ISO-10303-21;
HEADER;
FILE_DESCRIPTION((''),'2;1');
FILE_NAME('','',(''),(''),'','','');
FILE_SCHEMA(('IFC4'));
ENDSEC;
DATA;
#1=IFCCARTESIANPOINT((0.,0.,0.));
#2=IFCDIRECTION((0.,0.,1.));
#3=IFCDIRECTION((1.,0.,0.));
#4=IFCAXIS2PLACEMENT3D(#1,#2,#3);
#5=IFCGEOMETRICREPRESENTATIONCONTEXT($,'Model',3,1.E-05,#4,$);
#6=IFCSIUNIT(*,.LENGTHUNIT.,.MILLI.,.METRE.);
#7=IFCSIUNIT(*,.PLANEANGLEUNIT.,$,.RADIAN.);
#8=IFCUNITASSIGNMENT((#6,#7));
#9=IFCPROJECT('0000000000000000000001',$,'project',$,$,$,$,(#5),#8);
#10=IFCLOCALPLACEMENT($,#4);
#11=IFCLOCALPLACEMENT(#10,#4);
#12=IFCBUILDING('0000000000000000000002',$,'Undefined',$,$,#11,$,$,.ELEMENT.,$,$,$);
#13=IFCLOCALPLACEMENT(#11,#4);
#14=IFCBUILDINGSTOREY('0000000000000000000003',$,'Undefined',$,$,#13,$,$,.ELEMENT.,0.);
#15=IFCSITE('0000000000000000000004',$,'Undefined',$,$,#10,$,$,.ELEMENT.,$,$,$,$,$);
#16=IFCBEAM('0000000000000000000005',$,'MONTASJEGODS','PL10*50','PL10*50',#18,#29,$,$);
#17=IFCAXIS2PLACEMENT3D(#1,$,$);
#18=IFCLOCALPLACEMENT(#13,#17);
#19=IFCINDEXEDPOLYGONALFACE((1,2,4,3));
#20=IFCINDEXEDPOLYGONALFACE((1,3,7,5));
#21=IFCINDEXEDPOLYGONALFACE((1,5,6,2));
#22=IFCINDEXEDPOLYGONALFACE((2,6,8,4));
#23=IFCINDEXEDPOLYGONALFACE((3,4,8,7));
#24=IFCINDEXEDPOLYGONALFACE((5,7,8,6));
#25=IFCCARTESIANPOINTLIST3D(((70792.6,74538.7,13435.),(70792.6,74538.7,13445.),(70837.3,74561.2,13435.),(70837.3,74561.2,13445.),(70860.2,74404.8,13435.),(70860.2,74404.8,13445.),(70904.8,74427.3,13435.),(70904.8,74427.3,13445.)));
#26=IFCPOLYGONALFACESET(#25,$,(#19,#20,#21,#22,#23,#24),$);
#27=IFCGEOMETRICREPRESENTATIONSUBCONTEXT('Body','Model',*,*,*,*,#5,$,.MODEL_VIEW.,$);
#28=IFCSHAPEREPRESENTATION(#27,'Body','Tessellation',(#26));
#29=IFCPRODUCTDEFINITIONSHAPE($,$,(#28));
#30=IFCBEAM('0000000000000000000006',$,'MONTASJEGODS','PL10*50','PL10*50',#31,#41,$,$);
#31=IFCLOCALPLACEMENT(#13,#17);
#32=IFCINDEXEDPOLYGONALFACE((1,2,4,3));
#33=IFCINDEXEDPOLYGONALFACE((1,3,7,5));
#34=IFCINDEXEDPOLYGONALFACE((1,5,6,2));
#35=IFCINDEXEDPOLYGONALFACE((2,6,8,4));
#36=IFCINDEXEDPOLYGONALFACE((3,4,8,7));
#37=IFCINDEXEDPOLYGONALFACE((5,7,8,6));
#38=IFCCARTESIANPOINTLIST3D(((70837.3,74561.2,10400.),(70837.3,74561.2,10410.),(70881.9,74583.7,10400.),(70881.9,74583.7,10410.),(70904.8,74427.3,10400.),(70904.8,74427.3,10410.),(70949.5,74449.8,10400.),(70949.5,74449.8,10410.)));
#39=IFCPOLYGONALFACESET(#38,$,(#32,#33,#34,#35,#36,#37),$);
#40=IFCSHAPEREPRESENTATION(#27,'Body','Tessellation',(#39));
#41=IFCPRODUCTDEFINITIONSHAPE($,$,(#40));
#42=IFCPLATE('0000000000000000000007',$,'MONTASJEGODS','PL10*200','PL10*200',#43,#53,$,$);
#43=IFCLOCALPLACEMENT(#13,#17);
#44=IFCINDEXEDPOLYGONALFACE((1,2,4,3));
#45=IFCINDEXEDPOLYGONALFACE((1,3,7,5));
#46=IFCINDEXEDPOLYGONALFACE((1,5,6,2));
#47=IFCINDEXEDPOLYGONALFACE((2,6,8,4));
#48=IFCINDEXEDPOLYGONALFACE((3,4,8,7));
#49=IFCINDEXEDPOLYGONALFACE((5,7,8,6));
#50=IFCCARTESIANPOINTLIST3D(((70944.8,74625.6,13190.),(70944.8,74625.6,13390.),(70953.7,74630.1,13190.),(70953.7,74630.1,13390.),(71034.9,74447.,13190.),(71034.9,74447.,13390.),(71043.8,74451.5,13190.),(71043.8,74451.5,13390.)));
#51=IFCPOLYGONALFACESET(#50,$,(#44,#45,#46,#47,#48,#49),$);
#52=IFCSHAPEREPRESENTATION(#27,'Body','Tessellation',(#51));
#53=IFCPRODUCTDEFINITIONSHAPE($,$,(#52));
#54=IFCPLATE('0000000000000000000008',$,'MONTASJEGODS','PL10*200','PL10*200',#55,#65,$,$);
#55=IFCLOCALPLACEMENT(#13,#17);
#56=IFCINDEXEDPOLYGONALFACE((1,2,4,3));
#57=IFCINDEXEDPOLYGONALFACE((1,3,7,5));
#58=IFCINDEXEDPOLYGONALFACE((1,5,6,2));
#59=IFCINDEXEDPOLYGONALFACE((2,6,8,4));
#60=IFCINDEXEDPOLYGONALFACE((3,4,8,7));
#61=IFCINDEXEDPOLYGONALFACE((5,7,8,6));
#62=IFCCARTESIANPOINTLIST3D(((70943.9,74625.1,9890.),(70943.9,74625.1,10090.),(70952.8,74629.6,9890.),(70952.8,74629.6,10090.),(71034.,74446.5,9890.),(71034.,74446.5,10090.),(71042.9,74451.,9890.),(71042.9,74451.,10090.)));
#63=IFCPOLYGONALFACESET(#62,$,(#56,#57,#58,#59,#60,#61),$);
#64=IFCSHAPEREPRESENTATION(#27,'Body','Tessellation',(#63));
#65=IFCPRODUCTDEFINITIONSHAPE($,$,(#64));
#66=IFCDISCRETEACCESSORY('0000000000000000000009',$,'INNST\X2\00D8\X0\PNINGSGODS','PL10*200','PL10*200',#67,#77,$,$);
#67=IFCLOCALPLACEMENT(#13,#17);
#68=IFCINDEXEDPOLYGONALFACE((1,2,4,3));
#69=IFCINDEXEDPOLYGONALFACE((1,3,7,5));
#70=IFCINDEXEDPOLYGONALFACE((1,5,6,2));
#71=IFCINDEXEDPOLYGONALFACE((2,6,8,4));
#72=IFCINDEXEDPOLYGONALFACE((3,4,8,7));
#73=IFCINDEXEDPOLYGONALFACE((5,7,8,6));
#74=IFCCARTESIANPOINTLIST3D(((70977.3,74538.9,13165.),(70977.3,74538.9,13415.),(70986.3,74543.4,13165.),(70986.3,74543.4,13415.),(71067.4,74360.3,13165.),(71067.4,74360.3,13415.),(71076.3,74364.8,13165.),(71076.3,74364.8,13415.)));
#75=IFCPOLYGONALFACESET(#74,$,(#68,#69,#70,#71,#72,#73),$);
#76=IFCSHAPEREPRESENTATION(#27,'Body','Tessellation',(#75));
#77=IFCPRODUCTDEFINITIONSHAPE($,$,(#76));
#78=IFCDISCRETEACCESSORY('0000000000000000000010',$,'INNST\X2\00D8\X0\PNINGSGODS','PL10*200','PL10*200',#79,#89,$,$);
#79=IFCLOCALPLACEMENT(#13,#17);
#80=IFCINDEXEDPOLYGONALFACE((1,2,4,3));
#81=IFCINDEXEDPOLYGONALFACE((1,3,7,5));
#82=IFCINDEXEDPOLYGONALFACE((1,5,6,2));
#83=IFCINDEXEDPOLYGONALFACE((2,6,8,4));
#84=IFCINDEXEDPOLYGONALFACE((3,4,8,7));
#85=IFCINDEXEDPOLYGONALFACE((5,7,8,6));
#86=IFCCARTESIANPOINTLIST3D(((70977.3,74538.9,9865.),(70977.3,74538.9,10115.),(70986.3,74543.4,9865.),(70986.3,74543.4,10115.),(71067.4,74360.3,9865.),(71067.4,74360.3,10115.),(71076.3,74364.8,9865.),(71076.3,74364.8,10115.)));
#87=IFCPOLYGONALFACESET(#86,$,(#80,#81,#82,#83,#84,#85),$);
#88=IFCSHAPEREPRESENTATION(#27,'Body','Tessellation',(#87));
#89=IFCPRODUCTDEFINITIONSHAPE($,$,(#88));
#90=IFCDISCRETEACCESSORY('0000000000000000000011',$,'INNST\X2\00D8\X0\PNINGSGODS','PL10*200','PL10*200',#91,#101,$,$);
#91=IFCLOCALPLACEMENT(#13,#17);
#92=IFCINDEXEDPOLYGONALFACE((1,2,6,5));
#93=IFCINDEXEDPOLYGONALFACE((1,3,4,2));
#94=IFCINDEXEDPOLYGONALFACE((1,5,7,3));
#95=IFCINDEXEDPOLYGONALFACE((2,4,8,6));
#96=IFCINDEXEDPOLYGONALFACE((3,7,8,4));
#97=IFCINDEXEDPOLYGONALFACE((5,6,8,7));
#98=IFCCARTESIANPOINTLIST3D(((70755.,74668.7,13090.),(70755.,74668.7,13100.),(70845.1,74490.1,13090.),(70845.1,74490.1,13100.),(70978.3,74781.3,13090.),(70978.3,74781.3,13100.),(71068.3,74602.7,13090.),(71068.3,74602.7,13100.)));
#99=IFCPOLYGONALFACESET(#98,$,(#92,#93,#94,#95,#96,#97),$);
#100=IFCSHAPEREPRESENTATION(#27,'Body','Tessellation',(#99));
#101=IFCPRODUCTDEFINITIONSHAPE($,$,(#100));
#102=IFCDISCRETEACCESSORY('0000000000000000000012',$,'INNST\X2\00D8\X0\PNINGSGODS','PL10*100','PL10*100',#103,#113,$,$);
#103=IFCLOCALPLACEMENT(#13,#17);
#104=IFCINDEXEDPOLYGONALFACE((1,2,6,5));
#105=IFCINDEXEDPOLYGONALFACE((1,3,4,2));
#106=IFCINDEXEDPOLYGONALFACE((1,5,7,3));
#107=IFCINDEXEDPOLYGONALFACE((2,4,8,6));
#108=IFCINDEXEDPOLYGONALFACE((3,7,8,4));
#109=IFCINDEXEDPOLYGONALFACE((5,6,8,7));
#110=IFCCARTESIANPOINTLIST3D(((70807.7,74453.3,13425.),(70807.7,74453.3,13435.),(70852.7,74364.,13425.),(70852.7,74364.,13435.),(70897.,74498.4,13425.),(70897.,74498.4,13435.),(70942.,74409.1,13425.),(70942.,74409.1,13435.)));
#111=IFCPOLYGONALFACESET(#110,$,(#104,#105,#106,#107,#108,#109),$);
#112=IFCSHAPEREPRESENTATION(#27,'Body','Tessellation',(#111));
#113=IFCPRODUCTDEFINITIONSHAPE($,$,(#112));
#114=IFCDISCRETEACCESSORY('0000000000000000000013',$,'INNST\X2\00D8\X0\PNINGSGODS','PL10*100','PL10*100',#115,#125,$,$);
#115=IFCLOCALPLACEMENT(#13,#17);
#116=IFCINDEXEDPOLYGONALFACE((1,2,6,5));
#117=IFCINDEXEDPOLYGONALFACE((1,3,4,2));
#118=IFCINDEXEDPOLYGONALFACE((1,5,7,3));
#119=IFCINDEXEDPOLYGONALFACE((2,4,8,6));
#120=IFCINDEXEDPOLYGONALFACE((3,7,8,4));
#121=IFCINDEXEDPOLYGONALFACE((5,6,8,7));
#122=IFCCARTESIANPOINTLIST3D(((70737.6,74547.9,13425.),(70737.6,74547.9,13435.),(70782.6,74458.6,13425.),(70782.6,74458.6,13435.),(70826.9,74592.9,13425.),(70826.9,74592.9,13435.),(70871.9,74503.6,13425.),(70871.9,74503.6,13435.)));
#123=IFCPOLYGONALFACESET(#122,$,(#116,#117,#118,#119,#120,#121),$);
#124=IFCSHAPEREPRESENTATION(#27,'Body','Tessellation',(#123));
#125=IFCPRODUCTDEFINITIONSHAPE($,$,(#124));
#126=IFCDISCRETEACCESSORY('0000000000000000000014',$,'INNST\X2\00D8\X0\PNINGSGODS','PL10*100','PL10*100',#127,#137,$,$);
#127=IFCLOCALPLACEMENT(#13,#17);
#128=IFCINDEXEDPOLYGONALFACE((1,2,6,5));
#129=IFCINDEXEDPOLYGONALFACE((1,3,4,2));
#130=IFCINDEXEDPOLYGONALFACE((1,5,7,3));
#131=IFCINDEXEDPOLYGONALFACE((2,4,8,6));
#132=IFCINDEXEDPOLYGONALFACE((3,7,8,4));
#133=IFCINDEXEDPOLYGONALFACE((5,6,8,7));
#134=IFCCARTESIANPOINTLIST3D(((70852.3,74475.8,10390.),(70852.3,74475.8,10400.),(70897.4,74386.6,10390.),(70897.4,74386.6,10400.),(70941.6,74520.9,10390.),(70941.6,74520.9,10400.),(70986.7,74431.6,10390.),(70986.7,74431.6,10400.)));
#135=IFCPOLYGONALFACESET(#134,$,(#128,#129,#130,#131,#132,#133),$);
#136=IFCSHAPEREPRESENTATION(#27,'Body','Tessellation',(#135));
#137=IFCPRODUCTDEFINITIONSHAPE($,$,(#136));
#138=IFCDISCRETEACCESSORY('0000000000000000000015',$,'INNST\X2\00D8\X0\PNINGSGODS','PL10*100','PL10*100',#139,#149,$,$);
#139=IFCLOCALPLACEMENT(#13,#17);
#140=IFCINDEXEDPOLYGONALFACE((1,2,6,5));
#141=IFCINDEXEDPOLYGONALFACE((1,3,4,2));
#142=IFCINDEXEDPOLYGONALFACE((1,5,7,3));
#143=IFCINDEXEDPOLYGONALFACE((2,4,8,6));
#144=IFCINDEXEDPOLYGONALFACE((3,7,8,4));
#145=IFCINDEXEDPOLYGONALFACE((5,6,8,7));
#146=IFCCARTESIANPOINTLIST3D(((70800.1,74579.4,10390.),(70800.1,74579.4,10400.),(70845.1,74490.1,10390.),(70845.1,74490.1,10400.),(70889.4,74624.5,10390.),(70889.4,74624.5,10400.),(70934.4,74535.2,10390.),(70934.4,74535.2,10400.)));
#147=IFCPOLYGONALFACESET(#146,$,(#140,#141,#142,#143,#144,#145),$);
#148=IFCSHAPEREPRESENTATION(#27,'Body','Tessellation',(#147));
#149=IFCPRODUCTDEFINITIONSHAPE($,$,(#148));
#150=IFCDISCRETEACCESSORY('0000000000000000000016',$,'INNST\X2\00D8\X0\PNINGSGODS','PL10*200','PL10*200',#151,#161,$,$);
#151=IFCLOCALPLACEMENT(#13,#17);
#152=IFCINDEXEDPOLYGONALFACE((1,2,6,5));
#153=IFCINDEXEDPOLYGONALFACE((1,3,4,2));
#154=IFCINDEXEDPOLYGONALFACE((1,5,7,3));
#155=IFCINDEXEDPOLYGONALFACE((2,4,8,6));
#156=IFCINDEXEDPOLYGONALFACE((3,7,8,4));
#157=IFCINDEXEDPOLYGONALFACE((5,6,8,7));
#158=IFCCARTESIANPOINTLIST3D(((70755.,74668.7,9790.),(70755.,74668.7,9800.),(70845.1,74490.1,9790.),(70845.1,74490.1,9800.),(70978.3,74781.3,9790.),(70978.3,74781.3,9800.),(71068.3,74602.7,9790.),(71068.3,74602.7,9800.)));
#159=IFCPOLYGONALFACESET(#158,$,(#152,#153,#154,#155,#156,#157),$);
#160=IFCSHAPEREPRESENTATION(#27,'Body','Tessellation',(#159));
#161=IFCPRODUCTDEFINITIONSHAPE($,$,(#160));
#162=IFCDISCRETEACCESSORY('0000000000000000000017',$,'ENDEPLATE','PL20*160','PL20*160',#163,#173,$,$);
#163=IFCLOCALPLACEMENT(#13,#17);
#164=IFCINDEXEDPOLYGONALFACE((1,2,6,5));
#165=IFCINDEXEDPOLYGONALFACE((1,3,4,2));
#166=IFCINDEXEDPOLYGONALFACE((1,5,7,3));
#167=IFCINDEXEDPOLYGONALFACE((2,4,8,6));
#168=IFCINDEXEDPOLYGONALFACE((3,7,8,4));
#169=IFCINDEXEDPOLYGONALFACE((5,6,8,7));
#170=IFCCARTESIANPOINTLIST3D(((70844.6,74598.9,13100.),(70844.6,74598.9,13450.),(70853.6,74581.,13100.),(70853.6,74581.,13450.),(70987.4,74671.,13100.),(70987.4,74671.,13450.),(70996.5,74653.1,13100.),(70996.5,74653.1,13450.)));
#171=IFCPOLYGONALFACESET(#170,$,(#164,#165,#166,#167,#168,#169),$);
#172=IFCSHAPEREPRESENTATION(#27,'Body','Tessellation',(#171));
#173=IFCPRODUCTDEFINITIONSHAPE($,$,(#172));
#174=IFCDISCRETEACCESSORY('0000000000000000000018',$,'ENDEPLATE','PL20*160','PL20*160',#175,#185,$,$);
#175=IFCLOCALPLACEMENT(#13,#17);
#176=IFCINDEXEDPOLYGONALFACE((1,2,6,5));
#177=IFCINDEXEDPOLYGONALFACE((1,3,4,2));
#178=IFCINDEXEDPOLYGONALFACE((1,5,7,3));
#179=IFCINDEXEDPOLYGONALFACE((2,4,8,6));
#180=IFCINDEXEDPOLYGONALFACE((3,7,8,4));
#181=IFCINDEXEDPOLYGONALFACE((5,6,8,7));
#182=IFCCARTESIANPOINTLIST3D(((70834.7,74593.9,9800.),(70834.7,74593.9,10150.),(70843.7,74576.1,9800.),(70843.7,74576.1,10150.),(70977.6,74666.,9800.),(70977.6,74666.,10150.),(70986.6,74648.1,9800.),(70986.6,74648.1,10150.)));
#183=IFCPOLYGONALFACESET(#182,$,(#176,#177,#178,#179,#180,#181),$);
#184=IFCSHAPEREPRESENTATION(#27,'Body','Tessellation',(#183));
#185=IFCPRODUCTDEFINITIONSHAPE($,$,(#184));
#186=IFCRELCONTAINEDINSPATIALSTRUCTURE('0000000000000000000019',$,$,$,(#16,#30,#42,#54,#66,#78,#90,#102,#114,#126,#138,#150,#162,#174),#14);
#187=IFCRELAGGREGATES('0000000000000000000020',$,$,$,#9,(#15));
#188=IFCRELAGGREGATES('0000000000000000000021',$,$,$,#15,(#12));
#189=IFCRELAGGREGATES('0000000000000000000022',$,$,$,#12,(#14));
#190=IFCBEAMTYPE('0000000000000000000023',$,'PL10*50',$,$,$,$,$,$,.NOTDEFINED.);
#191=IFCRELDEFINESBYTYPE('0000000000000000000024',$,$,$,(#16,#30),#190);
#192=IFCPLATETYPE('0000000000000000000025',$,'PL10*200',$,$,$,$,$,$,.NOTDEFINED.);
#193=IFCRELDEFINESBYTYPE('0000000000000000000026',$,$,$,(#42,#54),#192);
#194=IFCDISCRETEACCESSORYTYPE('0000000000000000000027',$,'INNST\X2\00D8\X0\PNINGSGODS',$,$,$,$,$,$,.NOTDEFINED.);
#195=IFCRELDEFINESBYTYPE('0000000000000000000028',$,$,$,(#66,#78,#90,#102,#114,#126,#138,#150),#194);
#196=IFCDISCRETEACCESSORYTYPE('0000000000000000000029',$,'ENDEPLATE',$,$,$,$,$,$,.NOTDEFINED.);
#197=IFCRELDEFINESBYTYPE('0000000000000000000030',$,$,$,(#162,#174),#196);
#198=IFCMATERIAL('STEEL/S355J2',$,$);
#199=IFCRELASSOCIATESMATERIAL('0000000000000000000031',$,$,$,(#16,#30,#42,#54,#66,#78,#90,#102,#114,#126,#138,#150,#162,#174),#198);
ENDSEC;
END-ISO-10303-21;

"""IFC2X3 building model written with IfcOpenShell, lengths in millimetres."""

from ifc_helpers import new_model, si_unit, frame, origin_with_axes, origin_2d_with_axis, place, context, subcontext, project, spatial, polyline, rectangle, outline, extrude, material, type_object, element, save


model = new_model("IFC2X3")

# Units and contexts
model_context = context("Model", 3, precision=1e-05, world=origin_with_axes())
body_context = subcontext(model_context, "Body", "Model", "MODEL_VIEW")
ifc_project = project(units=[si_unit("LENGTHUNIT", "METRE", prefix="MILLI"), si_unit("PLANEANGLEUNIT", "RADIAN")], contexts=[model_context])

# Site, building, storey
site_placement = place(None, origin_with_axes())
site = spatial("IfcSite", under=ifc_project, at=site_placement, Name="Undefined", CompositionType="ELEMENT")
building_placement = place(site_placement, origin_with_axes())
building = spatial("IfcBuilding", under=site, at=building_placement, Name="Undefined", CompositionType="ELEMENT")
storey_placement = place(building_placement, origin_with_axes())
storey = spatial("IfcBuildingStorey", under=building, at=storey_placement, Name="Undefined", CompositionType="ELEMENT", Elevation=0.0)

# Beams
ifc_material_1 = material(Name="STEEL/S355J2")
beam_type_1 = type_object("IfcBeamType", Name="PL10*50", PredefinedType="NOTDEFINED")
for number, where, z_axis, x_axis, name in (
    (1, (70815.0, 74550.0, 13440.0), (0.892821, 0.450411, 0.0), (0.450411, -0.892821, 0.0), "MONTASJEGODS"),
    (2, (70859.6, 74572.5, 10405.0), (0.892821, 0.450411, 0.0), (0.450411, -0.892821, 0.0), "MONTASJEGODS"),
):
    element("IfcBeam", number, at=place(storey_placement, frame(where, z_axis=z_axis, x_axis=x_axis)), inside=storey, type_object=beam_type_1, material=ifc_material_1, Name=name, Description="PL10*50", ObjectType="PL10*50", context=body_context, shape_type="SweptSolid", body=[
        extrude(rectangle(XDim=10.0, YDim=50.0, at=origin_2d_with_axis()), frame((150.0, 0.0, 0.0), z_axis=(-1.0, 0.0, 0.0), x_axis=(0.0, -1.0, 0.0)), (0.0, 0.0, 1.0), 150.0),
    ])

# Plates
plate_type = type_object("IfcPlateType", Name="PL10*200", PredefinedType="NOTDEFINED")
for number, where, z_axis, x_axis, name in (
    (3, (71039.4, 74449.3, 13390.0), (-0.892821, -0.450411, 0.0), (-0.45041, 0.892822, 0.0), "MONTASJEGODS"),
    (4, (71038.4, 74448.8, 10090.0), (-0.892821, -0.450411, 0.0), (-0.45041, 0.892822, 0.0), "MONTASJEGODS"),
):
    element("IfcPlate", number, at=place(storey_placement, frame(where, z_axis=z_axis, x_axis=x_axis)), inside=storey, type_object=plate_type, material=ifc_material_1, Name=name, Description="PL10*200", ObjectType="PL10*200", context=body_context, shape_type="SweptSolid", body=[
        extrude(outline(polyline([(0.0, 0.0), (200.0, 0.0), (200.0, 200.0), (0.0, 200.0), (0.0, 0.0)])), frame((0.0, 0.0, -5.0), z_axis=(0.0, 0.0, 1.0), x_axis=(1.0, 0.0, 0.0)), (0.0, 0.0, 1.0), 10.0),
    ])

# Discrete accessories
discrete_accessory_type_1 = type_object("IfcDiscreteAccessoryType", Name="INNSTØPNINGSGODS")
for number, where, z_axis, x_axis, name in (
    (5, (71026.8, 74451.9, 13415.0), (0.892821, 0.450411, 0.0), (0.0, 0.0, -1.0), "INNSTØPNINGSGODS"),
    (6, (71026.8, 74451.9, 10115.0), (0.892821, 0.450411, 0.0), (0.0, 0.0, -1.0), "INNSTØPNINGSGODS"),
):
    element("IfcDiscreteAccessory", number, at=place(storey_placement, frame(where, z_axis=z_axis, x_axis=x_axis)), inside=storey, type_object=discrete_accessory_type_1, material=ifc_material_1, Name=name, Description="PL10*200", ObjectType="PL10*200", context=body_context, shape_type="SweptSolid", body=[
        extrude(outline(polyline([(250.0, 100.0), (250.0, -100.0), (0.0, -100.0), (0.0, 100.0), (250.0, 100.0)])), frame((0.0, 0.0, -5.0), z_axis=(0.0, 0.0, 1.0), x_axis=(1.0, 0.0, 0.0)), (0.0, 0.0, 1.0), 10.0),
    ])
discrete_accessory_1_placement = place(storey_placement, frame((71023.3, 74692.0, 13095.0), z_axis=(0.0, 0.0, 1.0), x_axis=(-0.892821, -0.450411, 0.0)))
element("IfcDiscreteAccessory", 7, at=discrete_accessory_1_placement, inside=storey, type_object=discrete_accessory_type_1, material=ifc_material_1, Name="INNSTØPNINGSGODS", Description="PL10*200", ObjectType="PL10*200", context=body_context, shape_type="SweptSolid", body=[
    extrude(outline(polyline([(250.0, -100.0), (0.0, -100.0), (0.0, 100.0), (250.0, 100.0), (250.0, -100.0)])), frame((0.0, 0.0, -5.0), z_axis=(0.0, 0.0, 1.0), x_axis=(1.0, 0.0, 0.0)), (0.0, 0.0, 1.0), 10.0),
])
discrete_accessory_2_placement = place(storey_placement, frame((70852.3, 74475.8, 13430.0), z_axis=(0.0, 0.0, 1.0), x_axis=(0.450411, -0.892821, 0.0)))
element("IfcDiscreteAccessory", 8, at=discrete_accessory_2_placement, inside=storey, type_object=discrete_accessory_type_1, material=ifc_material_1, Name="INNSTØPNINGSGODS", Description="PL10*100", ObjectType="PL10*100", context=body_context, shape_type="SweptSolid", body=[
    extrude(outline(polyline([(0.0, -50.0), (0.0, 50.0), (100.0, 50.0), (100.0, -50.0), (0.0, -50.0)])), frame((0.0, 0.0, -5.0), z_axis=(0.0, 0.0, 1.0), x_axis=(1.0, 0.0, 0.0)), (0.0, 0.0, 1.0), 10.0),
])
discrete_accessory_3_placement = place(storey_placement, frame((70827.3, 74481.1, 13430.0), z_axis=(0.0, 0.0, 1.0), x_axis=(-0.45041, 0.892822, 0.0)))
element("IfcDiscreteAccessory", 9, at=discrete_accessory_3_placement, inside=storey, type_object=discrete_accessory_type_1, material=ifc_material_1, Name="INNSTØPNINGSGODS", Description="PL10*100", ObjectType="PL10*100", context=body_context, shape_type="SweptSolid", body=[
    extrude(outline(polyline([(100.0, 50.0), (100.0, -50.0), (0.0, -50.0), (0.0, 50.0), (100.0, 50.0)])), frame((0.0, 0.0, -5.0), z_axis=(0.0, 0.0, 1.0), x_axis=(1.0, 0.0, 0.0)), (0.0, 0.0, 1.0), 10.0),
])
discrete_accessory_4_placement = place(storey_placement, frame((70897.0, 74498.4, 10395.0), z_axis=(0.0, 0.0, 1.0), x_axis=(0.450411, -0.892821, 0.0)))
element("IfcDiscreteAccessory", 10, at=discrete_accessory_4_placement, inside=storey, type_object=discrete_accessory_type_1, material=ifc_material_1, Name="INNSTØPNINGSGODS", Description="PL10*100", ObjectType="PL10*100", context=body_context, shape_type="SweptSolid", body=[
    extrude(outline(polyline([(0.0, -50.0), (0.0, 50.0), (100.0, 50.0), (100.0, -50.0), (0.0, -50.0)])), frame((0.0, 0.0, -5.0), z_axis=(0.0, 0.0, 1.0), x_axis=(1.0, 0.0, 0.0)), (0.0, 0.0, 1.0), 10.0),
])
discrete_accessory_5_placement = place(storey_placement, frame((70889.8, 74512.7, 10395.0), z_axis=(0.0, 0.0, 1.0), x_axis=(-0.45041, 0.892822, 0.0)))
element("IfcDiscreteAccessory", 11, at=discrete_accessory_5_placement, inside=storey, type_object=discrete_accessory_type_1, material=ifc_material_1, Name="INNSTØPNINGSGODS", Description="PL10*100", ObjectType="PL10*100", context=body_context, shape_type="SweptSolid", body=[
    extrude(outline(polyline([(100.0, 50.0), (100.0, -50.0), (0.0, -50.0), (0.0, 50.0), (100.0, 50.0)])), frame((0.0, 0.0, -5.0), z_axis=(0.0, 0.0, 1.0), x_axis=(1.0, 0.0, 0.0)), (0.0, 0.0, 1.0), 10.0),
])
discrete_accessory_6_placement = place(storey_placement, frame((71023.3, 74692.0, 9795.0), z_axis=(0.0, 0.0, 1.0), x_axis=(-0.892821, -0.450411, 0.0)))
element("IfcDiscreteAccessory", 12, at=discrete_accessory_6_placement, inside=storey, type_object=discrete_accessory_type_1, material=ifc_material_1, Name="INNSTØPNINGSGODS", Description="PL10*200", ObjectType="PL10*200", context=body_context, shape_type="SweptSolid", body=[
    extrude(outline(polyline([(250.0, -100.0), (0.0, -100.0), (0.0, 100.0), (250.0, 100.0), (250.0, -100.0)])), frame((0.0, 0.0, -5.0), z_axis=(0.0, 0.0, 1.0), x_axis=(1.0, 0.0, 0.0)), (0.0, 0.0, 1.0), 10.0),
])
discrete_accessory_type_2 = type_object("IfcDiscreteAccessoryType", Name="ENDEPLATE")
for number, where, z_axis, x_axis, name in (
    (13, (70920.5, 74626.0, 13100.0), (-0.450411, 0.892821, 0.0), (0.0, 0.0, 1.0), "ENDEPLATE"),
    (14, (70910.7, 74621.0, 9800.0), (-0.450411, 0.892821, 0.0), (0.0, 0.0, 1.0), "ENDEPLATE"),
):
    element("IfcDiscreteAccessory", number, at=place(storey_placement, frame(where, z_axis=z_axis, x_axis=x_axis)), inside=storey, type_object=discrete_accessory_type_2, material=ifc_material_1, Name=name, Description="PL20*160", ObjectType="PL20*160", context=body_context, shape_type="SweptSolid", body=[
        extrude(outline(polyline([(0.0, -80.0), (0.0, 80.0), (350.0, 80.0), (350.0, -80.0), (0.0, -80.0)])), frame((0.0, 0.0, -10.0), z_axis=(0.0, 0.0, 1.0), x_axis=(1.0, 0.0, 0.0)), (0.0, 0.0, 1.0), 20.0),
    ])

save(model, "model.ifc")
